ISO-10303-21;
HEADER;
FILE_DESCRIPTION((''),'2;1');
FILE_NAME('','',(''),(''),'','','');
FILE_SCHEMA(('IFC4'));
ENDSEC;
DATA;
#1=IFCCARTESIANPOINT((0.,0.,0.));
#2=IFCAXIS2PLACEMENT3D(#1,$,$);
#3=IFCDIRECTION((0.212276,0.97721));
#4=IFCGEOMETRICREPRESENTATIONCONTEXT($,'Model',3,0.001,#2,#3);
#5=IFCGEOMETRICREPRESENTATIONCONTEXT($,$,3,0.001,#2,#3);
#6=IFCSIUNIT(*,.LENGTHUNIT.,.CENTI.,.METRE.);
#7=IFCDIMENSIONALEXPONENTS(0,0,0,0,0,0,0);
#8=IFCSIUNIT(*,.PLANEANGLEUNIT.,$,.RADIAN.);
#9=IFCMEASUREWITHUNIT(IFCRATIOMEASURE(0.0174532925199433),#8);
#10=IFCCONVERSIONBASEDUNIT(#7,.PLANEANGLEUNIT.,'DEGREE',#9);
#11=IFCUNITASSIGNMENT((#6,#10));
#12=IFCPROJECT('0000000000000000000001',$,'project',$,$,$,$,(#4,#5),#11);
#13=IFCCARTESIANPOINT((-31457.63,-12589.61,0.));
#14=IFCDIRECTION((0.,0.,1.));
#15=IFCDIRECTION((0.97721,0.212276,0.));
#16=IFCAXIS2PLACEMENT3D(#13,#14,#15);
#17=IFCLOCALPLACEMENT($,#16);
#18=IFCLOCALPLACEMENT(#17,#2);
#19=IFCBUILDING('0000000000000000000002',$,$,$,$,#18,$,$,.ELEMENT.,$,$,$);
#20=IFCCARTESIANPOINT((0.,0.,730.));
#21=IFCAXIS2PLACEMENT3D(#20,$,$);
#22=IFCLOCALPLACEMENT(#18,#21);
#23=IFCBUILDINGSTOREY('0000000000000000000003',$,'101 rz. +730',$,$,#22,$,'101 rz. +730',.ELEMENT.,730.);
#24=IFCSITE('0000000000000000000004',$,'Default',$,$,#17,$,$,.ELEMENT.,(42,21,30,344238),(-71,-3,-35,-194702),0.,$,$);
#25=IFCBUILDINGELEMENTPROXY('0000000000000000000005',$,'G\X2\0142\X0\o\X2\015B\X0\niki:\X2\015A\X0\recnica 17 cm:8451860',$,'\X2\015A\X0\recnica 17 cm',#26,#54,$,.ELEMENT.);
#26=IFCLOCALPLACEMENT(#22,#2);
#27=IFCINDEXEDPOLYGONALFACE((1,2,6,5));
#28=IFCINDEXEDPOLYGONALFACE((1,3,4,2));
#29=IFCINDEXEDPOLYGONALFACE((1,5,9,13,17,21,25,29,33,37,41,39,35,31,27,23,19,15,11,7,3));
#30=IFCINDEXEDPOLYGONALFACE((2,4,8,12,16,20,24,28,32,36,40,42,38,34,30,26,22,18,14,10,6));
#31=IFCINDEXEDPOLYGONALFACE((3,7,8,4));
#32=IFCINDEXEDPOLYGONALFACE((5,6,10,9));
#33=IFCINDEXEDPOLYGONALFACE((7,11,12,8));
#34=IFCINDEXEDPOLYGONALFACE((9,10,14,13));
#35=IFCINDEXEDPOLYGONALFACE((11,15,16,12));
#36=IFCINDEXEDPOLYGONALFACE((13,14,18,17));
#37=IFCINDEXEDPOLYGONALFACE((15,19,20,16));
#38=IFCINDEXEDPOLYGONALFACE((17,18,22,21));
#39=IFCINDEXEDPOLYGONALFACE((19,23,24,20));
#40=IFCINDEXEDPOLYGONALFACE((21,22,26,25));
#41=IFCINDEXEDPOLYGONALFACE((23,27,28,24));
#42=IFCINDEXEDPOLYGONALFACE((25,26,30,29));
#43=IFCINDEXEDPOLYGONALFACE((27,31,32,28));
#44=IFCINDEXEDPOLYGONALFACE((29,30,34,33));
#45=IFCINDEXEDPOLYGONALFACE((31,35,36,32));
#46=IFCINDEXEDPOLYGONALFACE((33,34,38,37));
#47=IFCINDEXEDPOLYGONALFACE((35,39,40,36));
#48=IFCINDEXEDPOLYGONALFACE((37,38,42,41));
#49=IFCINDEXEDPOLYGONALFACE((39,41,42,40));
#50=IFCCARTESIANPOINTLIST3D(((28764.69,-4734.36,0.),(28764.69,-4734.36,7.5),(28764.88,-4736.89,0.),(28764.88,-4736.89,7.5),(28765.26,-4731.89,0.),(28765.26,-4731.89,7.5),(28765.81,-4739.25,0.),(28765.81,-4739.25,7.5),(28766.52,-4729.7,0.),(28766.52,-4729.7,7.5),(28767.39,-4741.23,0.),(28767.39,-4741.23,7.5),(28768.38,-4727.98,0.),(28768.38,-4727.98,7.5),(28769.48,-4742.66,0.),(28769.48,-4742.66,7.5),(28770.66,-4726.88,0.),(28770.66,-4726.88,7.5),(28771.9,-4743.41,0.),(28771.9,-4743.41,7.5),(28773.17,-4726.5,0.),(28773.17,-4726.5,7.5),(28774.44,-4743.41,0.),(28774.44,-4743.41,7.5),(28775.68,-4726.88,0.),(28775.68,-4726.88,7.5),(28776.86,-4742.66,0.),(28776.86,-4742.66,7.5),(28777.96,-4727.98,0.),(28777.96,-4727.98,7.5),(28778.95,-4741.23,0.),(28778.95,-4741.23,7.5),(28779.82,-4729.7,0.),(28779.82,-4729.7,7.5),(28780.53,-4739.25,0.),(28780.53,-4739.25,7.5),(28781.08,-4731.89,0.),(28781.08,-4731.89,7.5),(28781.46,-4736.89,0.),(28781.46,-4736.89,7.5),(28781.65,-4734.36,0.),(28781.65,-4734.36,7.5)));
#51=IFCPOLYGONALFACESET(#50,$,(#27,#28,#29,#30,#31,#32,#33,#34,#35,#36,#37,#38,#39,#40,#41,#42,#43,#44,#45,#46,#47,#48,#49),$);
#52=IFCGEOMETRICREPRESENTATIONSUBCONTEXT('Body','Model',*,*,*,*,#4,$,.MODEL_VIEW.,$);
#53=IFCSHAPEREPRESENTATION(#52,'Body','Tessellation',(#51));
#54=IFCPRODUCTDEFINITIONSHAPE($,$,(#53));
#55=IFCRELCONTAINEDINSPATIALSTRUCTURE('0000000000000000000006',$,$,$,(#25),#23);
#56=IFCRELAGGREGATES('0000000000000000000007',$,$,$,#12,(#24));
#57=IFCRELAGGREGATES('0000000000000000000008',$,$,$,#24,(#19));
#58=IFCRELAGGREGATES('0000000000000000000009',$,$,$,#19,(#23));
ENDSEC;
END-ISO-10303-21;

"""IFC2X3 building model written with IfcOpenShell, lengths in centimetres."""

from ifc_helpers import new_model, entity, si_unit, converted_unit, direction, frame, frame_2d, origin, place, context, subcontext, project, spatial, circle, extrude, source, transform, mapped, element, save


model = new_model("IFC2X3")

# Units and contexts
model_context = context("Model", 3, precision=0.001, world=origin(), true_north=direction((0.212276, 0.97721)))
context_of_model = context(None, 3, precision=0.001, world=origin(), true_north=direction((0.212276, 0.97721)))
body_context = subcontext(model_context, "Body", "Model", "MODEL_VIEW")
ifc_project = project(units=[si_unit("LENGTHUNIT", "METRE", prefix="CENTI"), converted_unit("PLANEANGLEUNIT", "DEGREE", entity("IfcRatioMeasure", 0.0174532925199433), si_unit("PLANEANGLEUNIT", "RADIAN"), dimensions=[0, 0, 0, 0, 0, 0, 0])], contexts=[model_context, context_of_model])

# Site, building, storey
site_placement = place(None, frame((-31457.63, -12589.61, 0.0), z_axis=(0.0, 0.0, 1.0), x_axis=(0.97721, 0.212276, 0.0)))
site = spatial("IfcSite", under=ifc_project, at=site_placement, Name="Default", CompositionType="ELEMENT", RefLatitude=(42, 21, 30, 344238), RefLongitude=(-71, -3, -35, -194702), RefElevation=0.0)
building_placement = place(site_placement, origin())
building = spatial("IfcBuilding", under=site, at=building_placement, CompositionType="ELEMENT")
storey_placement = place(building_placement, frame((0.0, 0.0, 730.0)))
storey = spatial("IfcBuildingStorey", under=building, at=storey_placement, Name="101 rz. +730", LongName="101 rz. +730", CompositionType="ELEMENT", Elevation=730.0)

# Building element proxy
shared_shape_1 = source(origin(), body_context, "Body", "SweptSolid", [
    extrude(circle(Radius=8.5, at=frame_2d((0.0, 0.0), x_axis=(1.0, 0.0))), frame((0.0, 0.0, 0.0), z_axis=(0.0, 0.0, 1.0), x_axis=(0.0, 1.0, 0.0)), (0.0, 0.0, 1.0), 7.5),
])
for number, where, name in (
    (1, (28773.17, -4735.0, 0.0), "Głośniki:Śrecnica 17 cm:8451860"),
):
    element("IfcBuildingElementProxy", number, at=place(storey_placement, frame(where)), inside=storey, Name=name, ObjectType="Śrecnica 17 cm", CompositionType="ELEMENT", context=body_context, shape_type="MappedRepresentation", body=[
        mapped(shared_shape_1, transform((0.0, 0.0, 0.0), scale=1.0)),
    ])

save(model, "model.ifc")
